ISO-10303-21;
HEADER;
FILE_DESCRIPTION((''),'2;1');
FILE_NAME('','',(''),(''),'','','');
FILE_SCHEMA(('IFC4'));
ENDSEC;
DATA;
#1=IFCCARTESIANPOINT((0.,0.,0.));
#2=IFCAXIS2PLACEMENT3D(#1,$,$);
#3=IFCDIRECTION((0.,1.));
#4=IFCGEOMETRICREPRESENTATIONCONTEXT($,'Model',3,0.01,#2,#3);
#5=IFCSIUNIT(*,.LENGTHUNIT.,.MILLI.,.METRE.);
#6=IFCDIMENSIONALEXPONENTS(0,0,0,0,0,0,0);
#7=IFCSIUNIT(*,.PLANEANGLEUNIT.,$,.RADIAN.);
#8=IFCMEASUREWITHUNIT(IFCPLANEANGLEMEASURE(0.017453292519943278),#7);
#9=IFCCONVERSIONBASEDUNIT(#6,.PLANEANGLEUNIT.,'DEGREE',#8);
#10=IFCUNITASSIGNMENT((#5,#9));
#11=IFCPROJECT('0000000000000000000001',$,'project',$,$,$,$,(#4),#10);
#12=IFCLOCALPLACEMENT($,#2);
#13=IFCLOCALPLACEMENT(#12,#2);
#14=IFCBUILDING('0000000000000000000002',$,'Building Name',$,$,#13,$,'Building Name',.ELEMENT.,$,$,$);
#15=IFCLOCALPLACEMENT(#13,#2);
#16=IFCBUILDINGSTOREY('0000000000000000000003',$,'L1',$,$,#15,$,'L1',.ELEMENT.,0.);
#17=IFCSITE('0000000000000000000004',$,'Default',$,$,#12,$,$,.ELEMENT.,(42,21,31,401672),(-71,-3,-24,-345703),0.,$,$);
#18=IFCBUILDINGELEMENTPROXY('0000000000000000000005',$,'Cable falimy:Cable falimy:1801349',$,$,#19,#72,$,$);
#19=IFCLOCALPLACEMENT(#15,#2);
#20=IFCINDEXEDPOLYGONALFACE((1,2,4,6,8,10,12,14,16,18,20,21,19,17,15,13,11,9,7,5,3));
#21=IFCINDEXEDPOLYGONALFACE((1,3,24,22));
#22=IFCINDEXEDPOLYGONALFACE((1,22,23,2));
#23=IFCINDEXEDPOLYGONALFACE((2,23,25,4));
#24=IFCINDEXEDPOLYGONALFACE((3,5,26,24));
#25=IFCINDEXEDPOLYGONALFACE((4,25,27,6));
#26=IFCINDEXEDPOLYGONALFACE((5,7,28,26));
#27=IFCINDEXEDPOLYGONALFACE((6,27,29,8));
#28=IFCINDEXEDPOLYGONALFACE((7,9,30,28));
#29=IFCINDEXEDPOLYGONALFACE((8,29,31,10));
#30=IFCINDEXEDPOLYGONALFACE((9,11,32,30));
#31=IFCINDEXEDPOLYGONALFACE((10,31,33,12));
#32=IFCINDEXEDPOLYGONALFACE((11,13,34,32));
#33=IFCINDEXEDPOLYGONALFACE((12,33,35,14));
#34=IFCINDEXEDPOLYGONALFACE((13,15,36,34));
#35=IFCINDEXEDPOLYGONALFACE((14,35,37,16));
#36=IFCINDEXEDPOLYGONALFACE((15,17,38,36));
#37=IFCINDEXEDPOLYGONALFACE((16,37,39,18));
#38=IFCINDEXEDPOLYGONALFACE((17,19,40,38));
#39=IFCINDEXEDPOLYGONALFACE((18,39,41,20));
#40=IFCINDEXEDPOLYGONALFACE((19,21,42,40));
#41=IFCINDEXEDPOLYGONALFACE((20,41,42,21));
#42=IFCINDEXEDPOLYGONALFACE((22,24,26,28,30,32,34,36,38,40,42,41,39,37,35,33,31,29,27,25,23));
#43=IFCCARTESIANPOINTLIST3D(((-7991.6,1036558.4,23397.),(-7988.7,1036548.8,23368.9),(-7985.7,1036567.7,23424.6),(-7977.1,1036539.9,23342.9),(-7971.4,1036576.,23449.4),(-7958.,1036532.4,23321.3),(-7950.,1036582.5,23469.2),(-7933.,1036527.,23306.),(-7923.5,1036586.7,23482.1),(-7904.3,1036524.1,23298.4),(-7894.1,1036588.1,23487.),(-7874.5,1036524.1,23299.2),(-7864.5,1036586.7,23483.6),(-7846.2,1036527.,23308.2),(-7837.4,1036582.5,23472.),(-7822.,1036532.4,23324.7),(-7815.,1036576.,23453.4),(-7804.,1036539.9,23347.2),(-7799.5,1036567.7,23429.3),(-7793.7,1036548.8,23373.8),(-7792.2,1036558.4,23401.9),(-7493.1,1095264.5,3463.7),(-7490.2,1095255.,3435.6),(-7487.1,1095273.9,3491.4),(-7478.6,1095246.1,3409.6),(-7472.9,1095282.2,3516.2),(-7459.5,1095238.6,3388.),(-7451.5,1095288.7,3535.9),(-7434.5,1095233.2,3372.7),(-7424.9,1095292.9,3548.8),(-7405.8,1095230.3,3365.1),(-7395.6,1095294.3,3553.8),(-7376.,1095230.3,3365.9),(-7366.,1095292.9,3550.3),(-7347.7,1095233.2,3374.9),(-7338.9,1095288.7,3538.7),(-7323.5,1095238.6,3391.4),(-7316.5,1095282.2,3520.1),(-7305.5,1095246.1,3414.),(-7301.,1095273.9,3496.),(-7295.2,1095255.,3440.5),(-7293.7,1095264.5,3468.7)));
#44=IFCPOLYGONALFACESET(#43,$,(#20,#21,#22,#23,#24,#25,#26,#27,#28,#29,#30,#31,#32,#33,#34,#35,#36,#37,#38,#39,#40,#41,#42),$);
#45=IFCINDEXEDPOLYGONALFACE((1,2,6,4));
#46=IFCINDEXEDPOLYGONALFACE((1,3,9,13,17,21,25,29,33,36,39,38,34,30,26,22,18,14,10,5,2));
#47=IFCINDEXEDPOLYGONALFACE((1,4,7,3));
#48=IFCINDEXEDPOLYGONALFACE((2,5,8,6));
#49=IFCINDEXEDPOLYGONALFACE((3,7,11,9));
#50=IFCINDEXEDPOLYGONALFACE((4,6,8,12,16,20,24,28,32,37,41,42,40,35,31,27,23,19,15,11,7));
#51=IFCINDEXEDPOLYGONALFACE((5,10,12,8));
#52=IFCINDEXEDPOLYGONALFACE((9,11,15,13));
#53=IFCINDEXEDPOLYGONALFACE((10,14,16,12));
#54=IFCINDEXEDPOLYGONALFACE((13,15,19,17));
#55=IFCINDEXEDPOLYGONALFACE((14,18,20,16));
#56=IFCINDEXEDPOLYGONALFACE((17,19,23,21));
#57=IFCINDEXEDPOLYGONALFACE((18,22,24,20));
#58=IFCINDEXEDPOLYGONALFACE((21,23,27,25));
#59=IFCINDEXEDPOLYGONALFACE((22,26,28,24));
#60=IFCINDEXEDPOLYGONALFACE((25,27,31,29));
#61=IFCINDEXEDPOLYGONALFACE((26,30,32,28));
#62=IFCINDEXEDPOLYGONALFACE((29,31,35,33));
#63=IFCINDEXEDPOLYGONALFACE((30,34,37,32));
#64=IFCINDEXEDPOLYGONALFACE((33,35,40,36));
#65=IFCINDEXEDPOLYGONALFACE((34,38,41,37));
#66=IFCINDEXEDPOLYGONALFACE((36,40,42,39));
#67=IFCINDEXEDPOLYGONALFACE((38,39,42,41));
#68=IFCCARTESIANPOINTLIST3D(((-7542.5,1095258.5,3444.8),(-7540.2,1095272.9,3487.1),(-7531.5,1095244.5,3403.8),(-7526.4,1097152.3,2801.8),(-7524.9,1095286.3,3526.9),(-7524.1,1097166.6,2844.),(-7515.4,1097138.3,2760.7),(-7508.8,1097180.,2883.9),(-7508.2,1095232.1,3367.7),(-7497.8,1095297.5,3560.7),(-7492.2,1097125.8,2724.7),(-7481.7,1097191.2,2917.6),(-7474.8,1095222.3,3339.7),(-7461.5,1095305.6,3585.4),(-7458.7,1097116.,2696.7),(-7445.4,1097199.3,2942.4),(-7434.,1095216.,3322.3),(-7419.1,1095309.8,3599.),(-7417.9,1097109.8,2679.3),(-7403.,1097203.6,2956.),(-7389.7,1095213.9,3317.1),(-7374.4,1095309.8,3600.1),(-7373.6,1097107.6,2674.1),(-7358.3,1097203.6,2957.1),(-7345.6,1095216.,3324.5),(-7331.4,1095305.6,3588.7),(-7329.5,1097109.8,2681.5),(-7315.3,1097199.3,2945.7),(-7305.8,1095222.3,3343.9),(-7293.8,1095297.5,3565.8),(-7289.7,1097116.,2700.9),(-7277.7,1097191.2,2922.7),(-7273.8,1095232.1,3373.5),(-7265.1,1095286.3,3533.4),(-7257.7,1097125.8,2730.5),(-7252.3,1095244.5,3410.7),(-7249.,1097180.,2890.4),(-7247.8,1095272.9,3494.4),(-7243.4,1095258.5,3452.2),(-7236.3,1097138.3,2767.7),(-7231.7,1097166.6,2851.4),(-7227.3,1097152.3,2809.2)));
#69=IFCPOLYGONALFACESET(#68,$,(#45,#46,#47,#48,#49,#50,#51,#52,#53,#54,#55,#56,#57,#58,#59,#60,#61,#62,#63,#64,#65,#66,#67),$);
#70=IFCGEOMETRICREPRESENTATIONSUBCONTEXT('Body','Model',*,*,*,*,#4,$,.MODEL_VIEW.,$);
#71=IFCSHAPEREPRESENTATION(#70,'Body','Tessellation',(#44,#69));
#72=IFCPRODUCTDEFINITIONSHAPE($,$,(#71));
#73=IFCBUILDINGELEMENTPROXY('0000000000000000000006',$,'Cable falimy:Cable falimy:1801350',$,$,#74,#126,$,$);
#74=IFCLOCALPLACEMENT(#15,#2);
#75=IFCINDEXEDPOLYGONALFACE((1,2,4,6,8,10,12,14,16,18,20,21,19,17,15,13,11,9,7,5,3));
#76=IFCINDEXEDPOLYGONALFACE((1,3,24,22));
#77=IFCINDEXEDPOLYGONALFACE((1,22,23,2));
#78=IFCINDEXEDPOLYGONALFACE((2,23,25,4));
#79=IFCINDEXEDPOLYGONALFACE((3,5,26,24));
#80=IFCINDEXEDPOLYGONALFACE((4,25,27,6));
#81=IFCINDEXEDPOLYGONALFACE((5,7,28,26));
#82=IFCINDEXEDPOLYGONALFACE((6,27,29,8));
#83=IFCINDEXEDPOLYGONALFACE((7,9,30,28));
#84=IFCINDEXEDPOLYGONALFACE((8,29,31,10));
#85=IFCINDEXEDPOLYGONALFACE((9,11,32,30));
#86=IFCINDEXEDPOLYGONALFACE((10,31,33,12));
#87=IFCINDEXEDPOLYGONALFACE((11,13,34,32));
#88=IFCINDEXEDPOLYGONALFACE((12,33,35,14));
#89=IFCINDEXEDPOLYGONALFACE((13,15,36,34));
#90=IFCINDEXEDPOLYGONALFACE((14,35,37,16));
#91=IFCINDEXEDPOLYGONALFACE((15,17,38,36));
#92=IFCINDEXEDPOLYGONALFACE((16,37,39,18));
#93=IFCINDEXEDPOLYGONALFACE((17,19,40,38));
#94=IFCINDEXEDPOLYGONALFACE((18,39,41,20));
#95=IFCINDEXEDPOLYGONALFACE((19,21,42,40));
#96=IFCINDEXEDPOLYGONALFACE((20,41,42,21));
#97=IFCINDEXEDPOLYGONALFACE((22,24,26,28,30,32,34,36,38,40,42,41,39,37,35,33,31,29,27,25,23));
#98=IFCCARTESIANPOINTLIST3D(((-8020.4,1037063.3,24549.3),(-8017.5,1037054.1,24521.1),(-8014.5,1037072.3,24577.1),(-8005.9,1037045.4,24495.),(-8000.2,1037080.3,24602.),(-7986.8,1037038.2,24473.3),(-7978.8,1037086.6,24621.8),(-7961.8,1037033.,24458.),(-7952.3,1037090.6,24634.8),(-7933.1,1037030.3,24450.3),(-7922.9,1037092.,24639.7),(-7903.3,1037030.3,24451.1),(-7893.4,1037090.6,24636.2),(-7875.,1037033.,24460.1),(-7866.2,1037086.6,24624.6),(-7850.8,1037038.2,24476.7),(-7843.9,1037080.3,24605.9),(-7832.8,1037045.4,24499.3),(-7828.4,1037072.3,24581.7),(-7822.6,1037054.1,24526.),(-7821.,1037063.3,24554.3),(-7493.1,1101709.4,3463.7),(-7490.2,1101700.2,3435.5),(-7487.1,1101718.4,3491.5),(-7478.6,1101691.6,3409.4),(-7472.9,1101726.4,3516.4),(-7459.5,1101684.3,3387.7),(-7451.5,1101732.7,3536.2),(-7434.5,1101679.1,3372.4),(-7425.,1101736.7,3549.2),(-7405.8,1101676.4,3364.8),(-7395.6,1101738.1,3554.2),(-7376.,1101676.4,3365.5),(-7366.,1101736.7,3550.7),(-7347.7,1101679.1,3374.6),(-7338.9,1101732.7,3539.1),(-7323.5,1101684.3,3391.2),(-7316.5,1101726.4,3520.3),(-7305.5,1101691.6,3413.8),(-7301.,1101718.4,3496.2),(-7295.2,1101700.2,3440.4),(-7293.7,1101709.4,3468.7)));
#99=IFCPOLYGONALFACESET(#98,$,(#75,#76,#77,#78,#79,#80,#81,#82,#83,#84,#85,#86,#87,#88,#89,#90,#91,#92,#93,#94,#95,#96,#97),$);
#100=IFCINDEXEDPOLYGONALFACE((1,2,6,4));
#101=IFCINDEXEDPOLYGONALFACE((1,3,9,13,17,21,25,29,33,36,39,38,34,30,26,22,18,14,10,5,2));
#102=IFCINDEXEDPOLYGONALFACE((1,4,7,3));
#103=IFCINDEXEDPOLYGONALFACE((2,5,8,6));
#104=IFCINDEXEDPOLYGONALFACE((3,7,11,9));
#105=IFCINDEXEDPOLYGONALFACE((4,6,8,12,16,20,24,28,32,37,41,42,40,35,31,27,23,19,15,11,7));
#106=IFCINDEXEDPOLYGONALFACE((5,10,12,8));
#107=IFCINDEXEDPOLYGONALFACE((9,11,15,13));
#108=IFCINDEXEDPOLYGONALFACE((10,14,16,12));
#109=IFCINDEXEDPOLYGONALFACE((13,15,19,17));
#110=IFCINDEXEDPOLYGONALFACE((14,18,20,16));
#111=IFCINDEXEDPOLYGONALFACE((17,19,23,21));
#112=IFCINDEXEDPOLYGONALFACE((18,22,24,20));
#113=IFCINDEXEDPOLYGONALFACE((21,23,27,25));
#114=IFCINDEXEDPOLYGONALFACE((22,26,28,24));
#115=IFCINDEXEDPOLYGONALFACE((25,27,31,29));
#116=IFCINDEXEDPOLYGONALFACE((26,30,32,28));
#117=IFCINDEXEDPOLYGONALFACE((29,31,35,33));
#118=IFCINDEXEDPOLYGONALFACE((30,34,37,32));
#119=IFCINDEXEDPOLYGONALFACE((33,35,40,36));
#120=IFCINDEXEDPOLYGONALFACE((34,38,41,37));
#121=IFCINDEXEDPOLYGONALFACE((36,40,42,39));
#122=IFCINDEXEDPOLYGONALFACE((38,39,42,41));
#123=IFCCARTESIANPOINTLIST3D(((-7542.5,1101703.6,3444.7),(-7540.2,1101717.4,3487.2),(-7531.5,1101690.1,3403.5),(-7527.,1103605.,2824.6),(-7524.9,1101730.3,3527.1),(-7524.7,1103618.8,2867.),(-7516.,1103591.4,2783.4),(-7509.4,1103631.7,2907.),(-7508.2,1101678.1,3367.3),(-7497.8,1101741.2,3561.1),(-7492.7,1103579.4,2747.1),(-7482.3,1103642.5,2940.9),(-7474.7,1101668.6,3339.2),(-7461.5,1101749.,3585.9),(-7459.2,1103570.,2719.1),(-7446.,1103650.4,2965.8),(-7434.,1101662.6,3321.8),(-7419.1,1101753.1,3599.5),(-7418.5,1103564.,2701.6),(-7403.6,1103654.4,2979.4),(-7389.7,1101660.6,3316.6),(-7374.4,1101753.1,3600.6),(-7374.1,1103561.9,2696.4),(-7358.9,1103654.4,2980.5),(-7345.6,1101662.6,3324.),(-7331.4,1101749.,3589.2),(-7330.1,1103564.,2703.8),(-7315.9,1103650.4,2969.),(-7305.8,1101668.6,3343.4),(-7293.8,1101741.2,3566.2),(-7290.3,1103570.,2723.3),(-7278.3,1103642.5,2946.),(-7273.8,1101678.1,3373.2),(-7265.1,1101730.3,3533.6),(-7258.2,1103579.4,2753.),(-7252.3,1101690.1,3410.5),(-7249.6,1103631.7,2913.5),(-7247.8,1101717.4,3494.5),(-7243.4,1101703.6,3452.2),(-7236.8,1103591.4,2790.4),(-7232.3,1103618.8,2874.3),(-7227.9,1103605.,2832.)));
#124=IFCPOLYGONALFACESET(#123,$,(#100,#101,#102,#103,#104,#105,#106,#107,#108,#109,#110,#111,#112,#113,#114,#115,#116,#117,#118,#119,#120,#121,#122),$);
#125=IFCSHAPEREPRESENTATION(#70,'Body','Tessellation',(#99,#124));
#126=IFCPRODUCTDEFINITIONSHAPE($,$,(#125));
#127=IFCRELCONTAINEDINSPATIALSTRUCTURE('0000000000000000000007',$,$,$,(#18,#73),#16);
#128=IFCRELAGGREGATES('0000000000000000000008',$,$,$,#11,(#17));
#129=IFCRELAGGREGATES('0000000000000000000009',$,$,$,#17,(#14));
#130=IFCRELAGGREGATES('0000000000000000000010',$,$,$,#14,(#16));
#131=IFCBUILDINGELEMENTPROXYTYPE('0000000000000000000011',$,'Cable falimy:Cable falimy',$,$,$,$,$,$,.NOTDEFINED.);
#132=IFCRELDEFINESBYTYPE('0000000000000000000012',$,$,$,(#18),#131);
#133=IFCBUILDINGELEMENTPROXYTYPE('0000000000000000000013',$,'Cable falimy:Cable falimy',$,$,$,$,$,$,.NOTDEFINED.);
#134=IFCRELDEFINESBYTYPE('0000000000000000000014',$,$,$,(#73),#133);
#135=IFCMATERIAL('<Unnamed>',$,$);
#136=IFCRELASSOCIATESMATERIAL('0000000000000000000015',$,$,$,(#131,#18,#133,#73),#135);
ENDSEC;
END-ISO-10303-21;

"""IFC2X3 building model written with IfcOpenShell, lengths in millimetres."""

from ifc_helpers import new_model, entity, si_unit, converted_unit, direction, frame, frame_2d, origin, place, context, subcontext, project, spatial, circle, extrude, source, transform, mapped, material, type_object, type_shapes, element, save


model = new_model("IFC2X3")

# Units and contexts
model_context = context("Model", 3, precision=0.01, world=origin(), true_north=direction((0.0, 1.0)))
body_context = subcontext(model_context, "Body", "Model", "MODEL_VIEW")
ifc_project = project(units=[si_unit("LENGTHUNIT", "METRE", prefix="MILLI"), converted_unit("PLANEANGLEUNIT", "DEGREE", entity("IfcPlaneAngleMeasure", 0.017453292519943278), si_unit("PLANEANGLEUNIT", "RADIAN"), dimensions=[0, 0, 0, 0, 0, 0, 0])], contexts=[model_context])

# Site, building, storey
site_placement = place(None, origin())
site = spatial("IfcSite", under=ifc_project, at=site_placement, Name="Default", CompositionType="ELEMENT", RefLatitude=(42, 21, 31, 401672), RefLongitude=(-71, -3, -24, -345703), RefElevation=0.0)
building_placement = place(site_placement, origin())
building = spatial("IfcBuilding", under=site, at=building_placement, Name="Building Name", LongName="Building Name", CompositionType="ELEMENT")
storey_placement = place(building_placement, origin())
storey = spatial("IfcBuildingStorey", under=building, at=storey_placement, Name="L1", LongName="L1", CompositionType="ELEMENT", Elevation=0.0)

# Shared definitions
ifc_material = material(Name="<Unnamed>")

# Building element proxies
building_element_proxy_type_1 = type_object("IfcBuildingElementProxyType", Name="Cable falimy:Cable falimy", PredefinedType="NOTDEFINED", material=ifc_material)
shared_shape_1 = source(origin(), body_context, "Body", "SweptSolid", [
    extrude(circle(Radius=100.0, at=frame_2d((0.0, 0.0), x_axis=(1.0, 0.0))), frame((0.0, 0.0, 0.0), z_axis=(0.946874, 0.0, 0.321605), x_axis=(-0.321605, 0.0, 0.946874)), (0.0, 0.0, 1.0), 62000.0),
    extrude(circle(Radius=150.0, at=frame_2d((0.0, 0.0), x_axis=(1.0, 0.0))), frame((-1893.7, 0.0, -643.2), z_axis=(0.946874, 0.0, 0.321605), x_axis=(0.321605, 0.0, -0.946874)), (0.0, 0.0, 1.0), 2000.0),
])
type_shapes(building_element_proxy_type_1, [shared_shape_1])
proxy_1_placement = place(storey_placement, frame((-7393.2, 1095262.1, 3459.1), z_axis=(-0.025001, 0.0, 0.999687), x_axis=(0.0, -1.0, 0.0)))
element("IfcBuildingElementProxy", 1, at=proxy_1_placement, inside=storey, type_object=building_element_proxy_type_1, material=ifc_material, Name="Cable falimy:Cable falimy:1801349", context=body_context, shape_type="MappedRepresentation", body=[
    mapped(shared_shape_1, transform((0.0, 0.0, 0.0), scale=1.0)),
])
building_element_proxy_type_2 = type_object("IfcBuildingElementProxyType", Name="Cable falimy:Cable falimy", PredefinedType="NOTDEFINED", material=ifc_material)
shared_shape_2 = source(origin(), body_context, "Body", "SweptSolid", [
    extrude(circle(Radius=100.0, at=frame_2d((0.0, 0.0), x_axis=(1.0, 0.0))), frame((0.0, 0.0, 0.0), z_axis=(0.950678, 0.0, 0.310179), x_axis=(-0.310179, 0.0, 0.950678)), (0.0, 0.0, 1.0), 68000.0),
    extrude(circle(Radius=150.0, at=frame_2d((0.0, 0.0), x_axis=(1.0, 0.0))), frame((-1901.4, 0.0, -620.4), z_axis=(0.950678, 0.0, 0.310179), x_axis=(0.310179, 0.0, -0.950678)), (0.0, 0.0, 1.0), 2000.0),
])
type_shapes(building_element_proxy_type_2, [shared_shape_2])
proxy_2_placement = place(storey_placement, frame((-7393.2, 1101707.1, 3459.1), z_axis=(-0.025001, 0.0, 0.999687), x_axis=(0.0, -1.0, 0.0)))
element("IfcBuildingElementProxy", 2, at=proxy_2_placement, inside=storey, type_object=building_element_proxy_type_2, material=ifc_material, Name="Cable falimy:Cable falimy:1801350", context=body_context, shape_type="MappedRepresentation", body=[
    mapped(shared_shape_2, transform((0.0, 0.0, 0.0), scale=1.0)),
])

save(model, "model.ifc")
